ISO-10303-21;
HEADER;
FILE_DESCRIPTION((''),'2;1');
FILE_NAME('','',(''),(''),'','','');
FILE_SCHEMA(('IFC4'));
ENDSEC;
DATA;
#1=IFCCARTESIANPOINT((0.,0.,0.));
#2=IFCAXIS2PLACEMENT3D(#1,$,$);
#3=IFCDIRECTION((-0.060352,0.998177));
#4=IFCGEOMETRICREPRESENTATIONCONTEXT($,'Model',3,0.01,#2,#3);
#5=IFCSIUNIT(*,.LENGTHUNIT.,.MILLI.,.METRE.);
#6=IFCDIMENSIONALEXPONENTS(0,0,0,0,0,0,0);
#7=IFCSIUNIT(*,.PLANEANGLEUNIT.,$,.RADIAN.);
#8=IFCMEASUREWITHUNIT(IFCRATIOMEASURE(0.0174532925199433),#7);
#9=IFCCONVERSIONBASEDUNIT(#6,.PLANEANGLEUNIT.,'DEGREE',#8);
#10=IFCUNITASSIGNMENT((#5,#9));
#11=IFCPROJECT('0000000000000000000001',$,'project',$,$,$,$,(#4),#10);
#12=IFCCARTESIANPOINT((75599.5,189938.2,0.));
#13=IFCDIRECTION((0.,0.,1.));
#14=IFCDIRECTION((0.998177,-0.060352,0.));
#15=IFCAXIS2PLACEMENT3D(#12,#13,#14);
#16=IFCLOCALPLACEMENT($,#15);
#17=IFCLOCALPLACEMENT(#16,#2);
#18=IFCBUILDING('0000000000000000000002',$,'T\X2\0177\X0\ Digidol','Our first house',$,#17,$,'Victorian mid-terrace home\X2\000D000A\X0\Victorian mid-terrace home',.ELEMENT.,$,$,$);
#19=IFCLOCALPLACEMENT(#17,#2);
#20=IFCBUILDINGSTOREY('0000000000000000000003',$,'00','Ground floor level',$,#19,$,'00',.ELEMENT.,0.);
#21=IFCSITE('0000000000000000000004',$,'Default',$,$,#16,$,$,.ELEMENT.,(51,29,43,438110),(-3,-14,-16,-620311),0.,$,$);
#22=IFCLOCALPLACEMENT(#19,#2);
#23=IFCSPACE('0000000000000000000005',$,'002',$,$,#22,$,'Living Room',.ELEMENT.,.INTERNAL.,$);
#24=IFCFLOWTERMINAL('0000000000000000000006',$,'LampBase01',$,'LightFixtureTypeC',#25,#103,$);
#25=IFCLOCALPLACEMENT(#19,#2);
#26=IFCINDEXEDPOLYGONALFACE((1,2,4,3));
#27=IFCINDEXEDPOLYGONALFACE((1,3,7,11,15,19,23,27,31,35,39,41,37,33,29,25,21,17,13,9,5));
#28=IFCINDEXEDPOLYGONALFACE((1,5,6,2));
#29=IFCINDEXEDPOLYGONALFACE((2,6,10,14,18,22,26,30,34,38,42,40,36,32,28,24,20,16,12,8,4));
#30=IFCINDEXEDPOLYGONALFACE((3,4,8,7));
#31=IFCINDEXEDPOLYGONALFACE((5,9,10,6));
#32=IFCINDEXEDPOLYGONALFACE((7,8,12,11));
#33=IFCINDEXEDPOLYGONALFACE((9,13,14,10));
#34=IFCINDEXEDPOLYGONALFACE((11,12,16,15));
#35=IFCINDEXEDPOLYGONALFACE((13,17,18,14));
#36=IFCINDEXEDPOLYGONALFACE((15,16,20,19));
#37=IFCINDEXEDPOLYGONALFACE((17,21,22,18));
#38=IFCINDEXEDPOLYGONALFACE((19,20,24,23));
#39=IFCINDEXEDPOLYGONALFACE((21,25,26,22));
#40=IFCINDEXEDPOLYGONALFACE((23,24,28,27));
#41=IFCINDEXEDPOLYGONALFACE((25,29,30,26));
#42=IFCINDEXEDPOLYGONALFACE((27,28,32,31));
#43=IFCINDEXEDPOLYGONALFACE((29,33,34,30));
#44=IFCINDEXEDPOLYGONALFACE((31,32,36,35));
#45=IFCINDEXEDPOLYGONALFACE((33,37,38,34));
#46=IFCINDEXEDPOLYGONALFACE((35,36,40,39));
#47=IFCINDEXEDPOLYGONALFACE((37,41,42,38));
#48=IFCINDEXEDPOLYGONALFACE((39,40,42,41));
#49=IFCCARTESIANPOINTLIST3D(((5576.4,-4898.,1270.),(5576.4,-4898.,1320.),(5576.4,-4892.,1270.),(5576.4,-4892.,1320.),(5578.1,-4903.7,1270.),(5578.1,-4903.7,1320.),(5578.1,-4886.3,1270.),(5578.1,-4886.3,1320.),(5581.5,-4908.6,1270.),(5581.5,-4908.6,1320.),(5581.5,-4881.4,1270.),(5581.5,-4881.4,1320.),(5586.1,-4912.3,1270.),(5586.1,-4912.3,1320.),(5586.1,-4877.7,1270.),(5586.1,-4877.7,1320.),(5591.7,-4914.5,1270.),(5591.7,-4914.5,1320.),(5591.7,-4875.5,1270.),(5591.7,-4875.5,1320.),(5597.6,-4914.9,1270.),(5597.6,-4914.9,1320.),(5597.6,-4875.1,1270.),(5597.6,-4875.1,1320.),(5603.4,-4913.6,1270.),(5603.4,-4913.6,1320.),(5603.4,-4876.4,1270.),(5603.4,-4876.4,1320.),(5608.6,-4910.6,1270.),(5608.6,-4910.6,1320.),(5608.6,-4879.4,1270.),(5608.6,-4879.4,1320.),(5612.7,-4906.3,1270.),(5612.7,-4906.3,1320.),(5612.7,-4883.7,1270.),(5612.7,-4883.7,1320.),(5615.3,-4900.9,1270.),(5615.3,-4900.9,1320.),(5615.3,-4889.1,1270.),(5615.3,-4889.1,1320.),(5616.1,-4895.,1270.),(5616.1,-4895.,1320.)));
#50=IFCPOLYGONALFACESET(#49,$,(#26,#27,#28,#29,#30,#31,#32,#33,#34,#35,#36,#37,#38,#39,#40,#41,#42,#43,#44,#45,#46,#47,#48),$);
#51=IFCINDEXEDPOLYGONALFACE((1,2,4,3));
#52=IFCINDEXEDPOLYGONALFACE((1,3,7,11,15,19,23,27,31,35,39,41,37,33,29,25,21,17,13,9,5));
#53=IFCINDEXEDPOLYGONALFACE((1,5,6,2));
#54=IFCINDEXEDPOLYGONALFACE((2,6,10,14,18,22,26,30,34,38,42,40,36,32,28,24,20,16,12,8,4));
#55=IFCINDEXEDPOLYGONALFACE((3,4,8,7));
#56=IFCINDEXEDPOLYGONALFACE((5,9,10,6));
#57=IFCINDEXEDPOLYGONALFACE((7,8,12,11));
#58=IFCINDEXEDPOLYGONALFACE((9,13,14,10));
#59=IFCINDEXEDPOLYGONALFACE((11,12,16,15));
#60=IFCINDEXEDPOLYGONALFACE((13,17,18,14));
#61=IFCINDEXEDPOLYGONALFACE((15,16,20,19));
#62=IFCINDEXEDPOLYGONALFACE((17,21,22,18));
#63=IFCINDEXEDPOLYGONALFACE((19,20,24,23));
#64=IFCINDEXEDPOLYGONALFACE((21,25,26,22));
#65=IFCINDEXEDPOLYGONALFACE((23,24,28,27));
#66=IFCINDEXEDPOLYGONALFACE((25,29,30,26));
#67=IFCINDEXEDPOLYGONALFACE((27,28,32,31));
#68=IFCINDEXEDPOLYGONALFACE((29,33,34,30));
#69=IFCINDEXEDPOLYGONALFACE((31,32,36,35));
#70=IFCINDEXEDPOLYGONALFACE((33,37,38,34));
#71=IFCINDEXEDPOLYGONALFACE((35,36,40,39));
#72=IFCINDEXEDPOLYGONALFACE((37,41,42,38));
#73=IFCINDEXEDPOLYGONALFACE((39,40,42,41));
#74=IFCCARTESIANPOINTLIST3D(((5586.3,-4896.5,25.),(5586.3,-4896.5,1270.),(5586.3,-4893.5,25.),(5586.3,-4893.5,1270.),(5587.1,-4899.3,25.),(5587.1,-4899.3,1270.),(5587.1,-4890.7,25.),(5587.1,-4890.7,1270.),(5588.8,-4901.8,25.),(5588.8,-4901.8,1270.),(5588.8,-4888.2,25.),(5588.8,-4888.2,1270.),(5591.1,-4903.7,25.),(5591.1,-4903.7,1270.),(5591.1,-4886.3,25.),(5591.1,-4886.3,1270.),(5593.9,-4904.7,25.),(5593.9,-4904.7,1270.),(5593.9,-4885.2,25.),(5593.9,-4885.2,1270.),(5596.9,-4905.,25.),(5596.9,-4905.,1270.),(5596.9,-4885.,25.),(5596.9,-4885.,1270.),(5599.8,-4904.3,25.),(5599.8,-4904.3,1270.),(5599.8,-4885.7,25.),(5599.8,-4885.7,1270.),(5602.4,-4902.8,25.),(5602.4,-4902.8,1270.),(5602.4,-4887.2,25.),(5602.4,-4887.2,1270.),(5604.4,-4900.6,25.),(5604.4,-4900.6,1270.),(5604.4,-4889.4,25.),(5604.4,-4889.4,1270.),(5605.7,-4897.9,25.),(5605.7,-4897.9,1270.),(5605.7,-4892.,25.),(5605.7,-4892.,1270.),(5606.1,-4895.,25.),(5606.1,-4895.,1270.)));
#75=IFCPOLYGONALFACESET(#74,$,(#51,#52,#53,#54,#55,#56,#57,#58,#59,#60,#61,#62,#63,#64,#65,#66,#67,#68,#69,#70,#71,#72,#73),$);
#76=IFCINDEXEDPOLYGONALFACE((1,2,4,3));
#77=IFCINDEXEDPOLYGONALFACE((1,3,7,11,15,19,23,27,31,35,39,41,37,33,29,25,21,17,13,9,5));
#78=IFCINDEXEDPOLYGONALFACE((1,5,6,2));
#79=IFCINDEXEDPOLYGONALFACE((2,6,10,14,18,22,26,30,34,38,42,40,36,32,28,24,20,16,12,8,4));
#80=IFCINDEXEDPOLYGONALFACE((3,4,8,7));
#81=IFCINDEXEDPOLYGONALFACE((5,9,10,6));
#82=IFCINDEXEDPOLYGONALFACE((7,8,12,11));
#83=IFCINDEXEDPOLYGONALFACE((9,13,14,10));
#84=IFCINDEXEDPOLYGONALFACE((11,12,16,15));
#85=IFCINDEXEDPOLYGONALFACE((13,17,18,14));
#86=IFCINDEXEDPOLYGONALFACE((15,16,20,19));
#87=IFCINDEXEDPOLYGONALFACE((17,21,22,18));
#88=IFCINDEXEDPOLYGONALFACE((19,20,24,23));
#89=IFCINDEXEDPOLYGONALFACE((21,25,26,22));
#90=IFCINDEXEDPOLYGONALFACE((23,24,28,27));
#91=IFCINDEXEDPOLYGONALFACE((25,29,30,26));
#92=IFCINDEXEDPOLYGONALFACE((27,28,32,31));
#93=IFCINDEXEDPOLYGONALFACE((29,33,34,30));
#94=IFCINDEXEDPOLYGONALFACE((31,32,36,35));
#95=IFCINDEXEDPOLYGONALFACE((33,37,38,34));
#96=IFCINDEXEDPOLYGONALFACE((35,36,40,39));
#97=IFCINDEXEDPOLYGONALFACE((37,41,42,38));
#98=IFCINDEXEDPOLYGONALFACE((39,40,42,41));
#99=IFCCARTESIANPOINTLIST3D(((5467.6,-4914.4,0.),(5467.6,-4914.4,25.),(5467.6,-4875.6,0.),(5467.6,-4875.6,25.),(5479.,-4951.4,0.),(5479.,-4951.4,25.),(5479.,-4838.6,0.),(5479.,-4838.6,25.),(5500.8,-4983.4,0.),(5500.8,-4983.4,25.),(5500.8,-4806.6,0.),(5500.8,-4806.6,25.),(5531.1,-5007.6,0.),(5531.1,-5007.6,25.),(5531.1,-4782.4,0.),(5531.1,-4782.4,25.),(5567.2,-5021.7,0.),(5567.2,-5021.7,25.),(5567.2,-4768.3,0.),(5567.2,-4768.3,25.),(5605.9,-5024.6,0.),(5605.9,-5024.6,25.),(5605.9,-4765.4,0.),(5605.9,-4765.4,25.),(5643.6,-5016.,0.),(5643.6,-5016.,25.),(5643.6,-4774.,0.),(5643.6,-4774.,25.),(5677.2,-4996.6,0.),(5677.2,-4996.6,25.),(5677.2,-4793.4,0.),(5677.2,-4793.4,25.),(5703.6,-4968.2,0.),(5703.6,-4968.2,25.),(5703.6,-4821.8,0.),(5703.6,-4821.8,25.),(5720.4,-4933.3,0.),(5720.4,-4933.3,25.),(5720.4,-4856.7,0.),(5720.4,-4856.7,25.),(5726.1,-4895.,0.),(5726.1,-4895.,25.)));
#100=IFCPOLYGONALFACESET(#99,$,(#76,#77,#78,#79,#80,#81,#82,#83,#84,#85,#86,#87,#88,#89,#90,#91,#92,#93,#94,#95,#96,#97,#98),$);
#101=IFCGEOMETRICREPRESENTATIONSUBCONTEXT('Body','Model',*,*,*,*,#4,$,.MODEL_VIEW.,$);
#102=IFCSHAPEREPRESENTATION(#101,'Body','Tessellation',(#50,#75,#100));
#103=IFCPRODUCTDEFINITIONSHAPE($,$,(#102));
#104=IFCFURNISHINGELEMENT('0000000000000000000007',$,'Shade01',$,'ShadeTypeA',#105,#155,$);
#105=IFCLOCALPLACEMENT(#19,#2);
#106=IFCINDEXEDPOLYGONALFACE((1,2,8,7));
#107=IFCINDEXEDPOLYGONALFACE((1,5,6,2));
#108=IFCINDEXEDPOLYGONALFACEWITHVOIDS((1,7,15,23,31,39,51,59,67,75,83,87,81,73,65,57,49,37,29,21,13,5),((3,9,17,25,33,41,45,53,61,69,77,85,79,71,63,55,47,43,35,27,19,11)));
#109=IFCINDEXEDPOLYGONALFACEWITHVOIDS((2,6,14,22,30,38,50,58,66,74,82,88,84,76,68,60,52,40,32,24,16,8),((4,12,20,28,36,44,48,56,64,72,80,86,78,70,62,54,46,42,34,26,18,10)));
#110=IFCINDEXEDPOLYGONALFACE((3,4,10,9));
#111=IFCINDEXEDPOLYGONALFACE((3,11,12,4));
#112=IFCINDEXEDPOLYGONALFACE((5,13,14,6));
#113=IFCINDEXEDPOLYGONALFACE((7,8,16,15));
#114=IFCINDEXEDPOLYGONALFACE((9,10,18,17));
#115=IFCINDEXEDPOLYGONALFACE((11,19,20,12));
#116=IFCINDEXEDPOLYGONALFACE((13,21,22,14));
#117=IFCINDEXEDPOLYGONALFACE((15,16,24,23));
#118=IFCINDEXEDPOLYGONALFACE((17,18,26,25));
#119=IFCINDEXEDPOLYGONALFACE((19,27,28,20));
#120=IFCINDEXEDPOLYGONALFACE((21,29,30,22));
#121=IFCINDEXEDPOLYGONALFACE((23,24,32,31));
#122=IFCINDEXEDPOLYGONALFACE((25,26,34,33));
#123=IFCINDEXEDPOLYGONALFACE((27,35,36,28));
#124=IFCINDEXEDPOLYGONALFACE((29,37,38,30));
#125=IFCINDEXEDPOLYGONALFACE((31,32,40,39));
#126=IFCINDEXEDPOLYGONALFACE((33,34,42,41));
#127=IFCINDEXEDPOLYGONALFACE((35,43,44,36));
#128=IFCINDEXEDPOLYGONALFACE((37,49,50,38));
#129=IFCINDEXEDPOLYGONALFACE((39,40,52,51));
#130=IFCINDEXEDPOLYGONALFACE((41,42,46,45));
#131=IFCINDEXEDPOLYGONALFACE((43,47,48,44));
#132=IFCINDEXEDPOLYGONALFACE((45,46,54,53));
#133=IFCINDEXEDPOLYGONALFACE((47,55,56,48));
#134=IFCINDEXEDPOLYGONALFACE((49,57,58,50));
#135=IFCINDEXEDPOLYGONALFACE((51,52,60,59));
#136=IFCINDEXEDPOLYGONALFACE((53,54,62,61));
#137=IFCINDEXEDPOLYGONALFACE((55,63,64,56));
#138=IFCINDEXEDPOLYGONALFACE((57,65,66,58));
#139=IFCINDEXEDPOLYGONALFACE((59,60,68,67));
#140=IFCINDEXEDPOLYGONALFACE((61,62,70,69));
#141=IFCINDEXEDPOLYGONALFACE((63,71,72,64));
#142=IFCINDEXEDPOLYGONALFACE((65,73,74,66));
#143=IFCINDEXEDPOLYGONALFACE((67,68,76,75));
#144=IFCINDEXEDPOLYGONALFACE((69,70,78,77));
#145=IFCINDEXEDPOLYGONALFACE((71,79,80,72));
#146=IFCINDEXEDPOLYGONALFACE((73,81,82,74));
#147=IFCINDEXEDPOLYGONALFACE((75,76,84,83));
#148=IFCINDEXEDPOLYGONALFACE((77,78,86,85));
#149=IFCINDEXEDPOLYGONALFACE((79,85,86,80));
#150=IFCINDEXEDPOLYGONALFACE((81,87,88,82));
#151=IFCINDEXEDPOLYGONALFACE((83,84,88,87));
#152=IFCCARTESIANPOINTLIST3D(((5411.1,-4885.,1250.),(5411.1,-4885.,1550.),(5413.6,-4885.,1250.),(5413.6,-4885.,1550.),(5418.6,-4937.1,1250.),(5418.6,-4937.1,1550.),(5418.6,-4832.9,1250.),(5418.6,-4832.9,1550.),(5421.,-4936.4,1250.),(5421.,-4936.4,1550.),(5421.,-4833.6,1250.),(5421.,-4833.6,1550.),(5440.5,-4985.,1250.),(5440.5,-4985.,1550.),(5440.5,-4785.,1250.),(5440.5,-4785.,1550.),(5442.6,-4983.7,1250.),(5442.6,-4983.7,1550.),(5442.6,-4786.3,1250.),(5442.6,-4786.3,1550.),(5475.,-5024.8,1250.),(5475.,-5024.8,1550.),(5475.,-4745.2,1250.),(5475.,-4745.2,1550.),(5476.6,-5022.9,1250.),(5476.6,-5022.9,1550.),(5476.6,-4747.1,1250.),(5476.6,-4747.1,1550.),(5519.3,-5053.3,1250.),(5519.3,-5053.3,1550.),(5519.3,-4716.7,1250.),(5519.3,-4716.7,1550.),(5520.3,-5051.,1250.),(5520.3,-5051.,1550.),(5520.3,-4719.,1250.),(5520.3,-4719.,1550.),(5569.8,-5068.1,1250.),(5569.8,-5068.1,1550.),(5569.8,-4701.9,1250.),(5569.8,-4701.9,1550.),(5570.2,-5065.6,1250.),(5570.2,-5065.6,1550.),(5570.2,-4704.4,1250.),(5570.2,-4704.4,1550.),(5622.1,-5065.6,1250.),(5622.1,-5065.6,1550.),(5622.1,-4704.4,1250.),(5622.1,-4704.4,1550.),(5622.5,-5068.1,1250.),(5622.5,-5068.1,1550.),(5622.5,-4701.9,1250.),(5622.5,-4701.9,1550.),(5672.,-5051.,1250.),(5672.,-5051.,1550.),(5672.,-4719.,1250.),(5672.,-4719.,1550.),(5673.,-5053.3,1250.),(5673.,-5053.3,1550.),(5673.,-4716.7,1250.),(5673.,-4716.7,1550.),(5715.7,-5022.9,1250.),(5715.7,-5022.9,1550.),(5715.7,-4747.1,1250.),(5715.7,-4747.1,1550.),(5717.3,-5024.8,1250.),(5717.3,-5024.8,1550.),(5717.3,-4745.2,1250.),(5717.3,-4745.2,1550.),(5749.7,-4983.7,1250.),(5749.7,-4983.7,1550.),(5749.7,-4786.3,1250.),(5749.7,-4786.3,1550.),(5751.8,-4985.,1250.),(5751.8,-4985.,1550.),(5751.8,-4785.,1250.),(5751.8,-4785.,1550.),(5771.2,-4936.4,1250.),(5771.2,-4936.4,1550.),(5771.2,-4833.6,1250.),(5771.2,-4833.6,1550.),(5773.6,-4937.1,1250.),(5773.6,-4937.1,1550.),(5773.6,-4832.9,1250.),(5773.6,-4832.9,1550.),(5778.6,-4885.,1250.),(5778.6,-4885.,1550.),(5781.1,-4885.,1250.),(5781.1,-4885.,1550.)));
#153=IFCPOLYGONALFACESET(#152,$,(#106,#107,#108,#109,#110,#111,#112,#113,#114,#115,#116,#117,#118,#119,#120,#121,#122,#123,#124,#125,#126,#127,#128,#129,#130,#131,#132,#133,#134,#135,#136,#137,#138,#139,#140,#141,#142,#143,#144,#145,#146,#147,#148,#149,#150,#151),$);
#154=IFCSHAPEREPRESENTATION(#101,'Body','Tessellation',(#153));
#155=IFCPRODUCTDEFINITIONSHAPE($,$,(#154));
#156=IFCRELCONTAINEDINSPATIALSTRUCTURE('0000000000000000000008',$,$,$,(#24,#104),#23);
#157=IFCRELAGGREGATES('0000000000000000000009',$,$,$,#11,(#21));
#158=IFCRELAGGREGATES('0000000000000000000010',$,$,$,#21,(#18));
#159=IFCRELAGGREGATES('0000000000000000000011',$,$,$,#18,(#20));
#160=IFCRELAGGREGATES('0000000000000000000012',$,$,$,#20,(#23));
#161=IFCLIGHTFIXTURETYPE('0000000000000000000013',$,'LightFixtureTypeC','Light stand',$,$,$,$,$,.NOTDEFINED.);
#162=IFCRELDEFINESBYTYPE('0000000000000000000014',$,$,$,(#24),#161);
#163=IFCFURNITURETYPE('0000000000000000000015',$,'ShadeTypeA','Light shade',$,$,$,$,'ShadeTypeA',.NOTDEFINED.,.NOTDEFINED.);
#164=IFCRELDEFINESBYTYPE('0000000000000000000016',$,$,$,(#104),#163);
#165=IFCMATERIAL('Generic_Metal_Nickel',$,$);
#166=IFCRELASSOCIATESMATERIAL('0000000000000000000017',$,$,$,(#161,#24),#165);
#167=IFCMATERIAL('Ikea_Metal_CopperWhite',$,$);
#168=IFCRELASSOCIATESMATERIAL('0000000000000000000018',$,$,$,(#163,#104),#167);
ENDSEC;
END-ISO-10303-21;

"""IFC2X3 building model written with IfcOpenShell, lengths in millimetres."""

from ifc_helpers import new_model, entity, si_unit, converted_unit, direction, frame, frame_2d, origin, place, context, subcontext, project, spatial, circle, hollow_circle, extrude, source, transform, mapped, material, type_object, type_shapes, element, save


model = new_model("IFC2X3")

# Units and contexts
model_context = context("Model", 3, precision=0.01, world=origin(), true_north=direction((-0.060352, 0.998177)))
body_context = subcontext(model_context, "Body", "Model", "MODEL_VIEW")
ifc_project = project(units=[si_unit("LENGTHUNIT", "METRE", prefix="MILLI"), converted_unit("PLANEANGLEUNIT", "DEGREE", entity("IfcRatioMeasure", 0.0174532925199433), si_unit("PLANEANGLEUNIT", "RADIAN"), dimensions=[0, 0, 0, 0, 0, 0, 0])], contexts=[model_context])

# Site, building, storey
site_placement = place(None, frame((75599.5, 189938.2, 0.0), z_axis=(0.0, 0.0, 1.0), x_axis=(0.998177, -0.060352, 0.0)))
site = spatial("IfcSite", under=ifc_project, at=site_placement, Name="Default", CompositionType="ELEMENT", RefLatitude=(51, 29, 43, 438110), RefLongitude=(-3, -14, -16, -620311), RefElevation=0.0)
building_placement = place(site_placement, origin())
building = spatial("IfcBuilding", under=site, at=building_placement, Name="Tŷ Digidol", Description="Our first house", LongName="Victorian mid-terrace home\r\nVictorian mid-terrace home", CompositionType="ELEMENT")
storey_placement = place(building_placement, origin())
storey = spatial("IfcBuildingStorey", under=building, at=storey_placement, Name="00", Description="Ground floor level", LongName="00", CompositionType="ELEMENT", Elevation=0.0)

# Shared definitions
space_1_placement = place(storey_placement, origin())
space_1 = spatial("IfcSpace", under=storey, at=space_1_placement, Name="002", LongName="Living Room", CompositionType="ELEMENT", InteriorOrExteriorSpace="INTERNAL")

# Flow terminal
ifc_material_1 = material(Name="Generic_Metal_Nickel")
light_fixture_type_1 = type_object("IfcLightFixtureType", Name="LightFixtureTypeC", Description="Light stand", PredefinedType="NOTDEFINED", material=ifc_material_1)
shared_shape_1 = source(origin(), body_context, "Body", "SweptSolid", [
    extrude(circle(Radius=20.0, at=frame_2d((0.0, 0.0), x_axis=(1.0, 0.0))), frame((0.0, 0.0, 1270.0)), (0.0, 0.0, 1.0), 50.0),
    extrude(circle(Radius=10.0, at=frame_2d((0.0, 0.0), x_axis=(1.0, 0.0))), frame((0.0, 0.0, 25.0)), (0.0, 0.0, 1.0), 1245.0),
    extrude(circle(Radius=130.0, at=frame_2d((0.0, 0.0), x_axis=(1.0, 0.0))), origin(), (0.0, 0.0, 1.0), 25.0),
])
type_shapes(light_fixture_type_1, [shared_shape_1])
flow_terminal_1_placement = place(space_1_placement, frame((5596.1, -4895.0, 0.0)))
element("IfcFlowTerminal", 1, at=flow_terminal_1_placement, inside=space_1, type_object=light_fixture_type_1, material=ifc_material_1, Name="LampBase01", ObjectType="LightFixtureTypeC", context=body_context, shape_type="MappedRepresentation", body=[
    mapped(shared_shape_1, transform((0.0, 0.0, 0.0), scale=1.0)),
])

# Furnishing element
ifc_material_2 = material(Name="Ikea_Metal_CopperWhite")
furniture_type = type_object("IfcFurnitureType", Name="ShadeTypeA", Description="Light shade", ElementType="ShadeTypeA", AssemblyPlace="NOTDEFINED", material=ifc_material_2)
shared_shape_2 = source(origin(), body_context, "Body", "SweptSolid", [
    extrude(hollow_circle(Radius=185.0, WallThickness=2.5, at=frame_2d((0.0, 0.0), x_axis=(1.0, 0.0))), origin(), (0.0, 0.0, 1.0), 300.0),
])
type_shapes(furniture_type, [shared_shape_2])
furnishing_placement = place(space_1_placement, frame((5596.1, -4885.0, 1250.0)))
element("IfcFurnishingElement", 2, at=furnishing_placement, inside=space_1, type_object=furniture_type, material=ifc_material_2, Name="Shade01", ObjectType="ShadeTypeA", context=body_context, shape_type="MappedRepresentation", body=[
    mapped(shared_shape_2, transform((0.0, 0.0, 0.0), scale=1.0)),
])

save(model, "model.ifc")
